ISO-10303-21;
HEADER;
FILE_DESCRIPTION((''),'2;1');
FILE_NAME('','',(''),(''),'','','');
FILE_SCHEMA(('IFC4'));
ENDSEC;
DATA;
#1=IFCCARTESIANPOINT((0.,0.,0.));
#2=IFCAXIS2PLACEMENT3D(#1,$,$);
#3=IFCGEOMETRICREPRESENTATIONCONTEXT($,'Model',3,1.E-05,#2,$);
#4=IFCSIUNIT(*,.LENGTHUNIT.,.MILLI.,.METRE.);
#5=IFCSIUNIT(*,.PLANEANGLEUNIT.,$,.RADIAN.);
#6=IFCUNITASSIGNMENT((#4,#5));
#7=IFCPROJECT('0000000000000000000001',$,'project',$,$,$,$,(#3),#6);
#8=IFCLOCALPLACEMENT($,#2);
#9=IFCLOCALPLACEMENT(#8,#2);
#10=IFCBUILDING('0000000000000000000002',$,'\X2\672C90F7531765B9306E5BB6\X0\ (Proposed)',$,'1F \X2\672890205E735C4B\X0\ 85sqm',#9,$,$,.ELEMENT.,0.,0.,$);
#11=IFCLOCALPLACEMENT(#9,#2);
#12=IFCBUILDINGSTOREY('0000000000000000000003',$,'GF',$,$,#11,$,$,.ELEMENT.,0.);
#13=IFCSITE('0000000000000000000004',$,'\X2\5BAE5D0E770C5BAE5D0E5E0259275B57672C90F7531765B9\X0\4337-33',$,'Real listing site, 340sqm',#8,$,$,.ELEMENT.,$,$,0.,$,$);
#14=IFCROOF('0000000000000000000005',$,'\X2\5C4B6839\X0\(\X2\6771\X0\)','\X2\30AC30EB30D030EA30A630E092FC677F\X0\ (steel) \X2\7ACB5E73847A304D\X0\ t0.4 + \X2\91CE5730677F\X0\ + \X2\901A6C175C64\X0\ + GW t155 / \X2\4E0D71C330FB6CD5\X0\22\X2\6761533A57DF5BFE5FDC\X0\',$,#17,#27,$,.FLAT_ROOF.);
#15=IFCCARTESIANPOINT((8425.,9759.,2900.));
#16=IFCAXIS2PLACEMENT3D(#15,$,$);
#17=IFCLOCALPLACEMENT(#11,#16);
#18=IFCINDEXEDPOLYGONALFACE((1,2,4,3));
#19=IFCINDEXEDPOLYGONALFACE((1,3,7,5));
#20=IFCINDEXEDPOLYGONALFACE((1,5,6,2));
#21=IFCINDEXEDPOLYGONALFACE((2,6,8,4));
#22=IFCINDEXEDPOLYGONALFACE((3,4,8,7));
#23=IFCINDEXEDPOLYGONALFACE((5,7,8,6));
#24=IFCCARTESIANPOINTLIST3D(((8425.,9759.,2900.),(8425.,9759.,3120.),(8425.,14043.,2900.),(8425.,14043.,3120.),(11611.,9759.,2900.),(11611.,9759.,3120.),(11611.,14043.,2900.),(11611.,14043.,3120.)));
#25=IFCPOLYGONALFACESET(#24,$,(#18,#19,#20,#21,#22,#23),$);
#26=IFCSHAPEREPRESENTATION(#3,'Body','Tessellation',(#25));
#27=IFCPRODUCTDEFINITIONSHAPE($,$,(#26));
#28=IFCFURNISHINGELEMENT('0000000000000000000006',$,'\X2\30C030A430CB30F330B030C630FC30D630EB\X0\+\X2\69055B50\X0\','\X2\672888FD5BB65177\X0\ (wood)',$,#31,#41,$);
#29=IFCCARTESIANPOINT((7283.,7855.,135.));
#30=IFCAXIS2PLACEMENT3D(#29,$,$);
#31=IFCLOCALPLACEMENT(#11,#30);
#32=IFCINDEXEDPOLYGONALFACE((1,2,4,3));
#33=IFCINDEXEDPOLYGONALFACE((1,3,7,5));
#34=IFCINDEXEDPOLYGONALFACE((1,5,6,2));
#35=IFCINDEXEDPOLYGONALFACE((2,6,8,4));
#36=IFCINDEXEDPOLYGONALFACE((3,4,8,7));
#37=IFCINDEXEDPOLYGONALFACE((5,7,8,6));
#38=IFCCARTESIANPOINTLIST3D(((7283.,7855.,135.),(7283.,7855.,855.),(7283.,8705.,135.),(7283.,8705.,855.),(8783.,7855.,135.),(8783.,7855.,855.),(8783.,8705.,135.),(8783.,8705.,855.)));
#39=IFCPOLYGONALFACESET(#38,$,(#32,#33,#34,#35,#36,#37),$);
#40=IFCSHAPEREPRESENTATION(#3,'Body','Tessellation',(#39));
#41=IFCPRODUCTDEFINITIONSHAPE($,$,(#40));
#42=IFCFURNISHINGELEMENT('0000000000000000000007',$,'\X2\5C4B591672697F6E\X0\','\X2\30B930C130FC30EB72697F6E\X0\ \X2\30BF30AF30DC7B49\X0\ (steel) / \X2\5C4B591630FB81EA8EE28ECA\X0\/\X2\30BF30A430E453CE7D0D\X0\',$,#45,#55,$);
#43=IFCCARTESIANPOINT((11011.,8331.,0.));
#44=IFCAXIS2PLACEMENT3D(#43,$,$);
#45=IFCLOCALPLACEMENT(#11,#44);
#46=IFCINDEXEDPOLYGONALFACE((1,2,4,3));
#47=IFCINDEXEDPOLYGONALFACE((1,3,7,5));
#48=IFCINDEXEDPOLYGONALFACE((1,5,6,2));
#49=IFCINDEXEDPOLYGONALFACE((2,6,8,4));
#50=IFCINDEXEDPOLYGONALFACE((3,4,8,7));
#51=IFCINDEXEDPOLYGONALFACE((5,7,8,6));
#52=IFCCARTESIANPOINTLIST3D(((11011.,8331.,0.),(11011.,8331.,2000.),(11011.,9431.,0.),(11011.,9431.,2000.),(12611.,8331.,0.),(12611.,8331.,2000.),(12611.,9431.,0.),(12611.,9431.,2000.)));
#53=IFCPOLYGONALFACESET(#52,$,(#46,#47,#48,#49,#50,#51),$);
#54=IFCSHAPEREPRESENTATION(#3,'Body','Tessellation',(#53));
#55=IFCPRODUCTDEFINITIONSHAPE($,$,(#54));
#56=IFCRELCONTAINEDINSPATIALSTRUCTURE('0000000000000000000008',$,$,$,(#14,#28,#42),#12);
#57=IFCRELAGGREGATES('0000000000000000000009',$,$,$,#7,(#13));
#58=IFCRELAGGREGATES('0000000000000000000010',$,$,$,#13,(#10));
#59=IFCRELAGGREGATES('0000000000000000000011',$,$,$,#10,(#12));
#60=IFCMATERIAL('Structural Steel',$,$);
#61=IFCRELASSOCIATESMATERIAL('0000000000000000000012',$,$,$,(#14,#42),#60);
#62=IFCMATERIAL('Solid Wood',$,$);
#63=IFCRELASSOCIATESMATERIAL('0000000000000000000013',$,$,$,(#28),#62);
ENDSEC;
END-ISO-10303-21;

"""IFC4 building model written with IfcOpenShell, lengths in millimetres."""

from ifc_helpers import new_model, si_unit, frame, frame_2d, origin, place, context, project, spatial, rectangle, extrude, material, element, save


model = new_model("IFC4")

# Units and contexts
model_context = context("Model", 3, precision=1e-05, world=origin())
ifc_project = project(units=[si_unit("LENGTHUNIT", "METRE", prefix="MILLI"), si_unit("PLANEANGLEUNIT", "RADIAN")], contexts=[model_context])

# Site, building, storey
site_placement = place(None, origin())
site = spatial("IfcSite", under=ifc_project, at=site_placement, Name="宮崎県宮崎市大字本郷北方4337-33", ObjectType="Real listing site, 340sqm", CompositionType="ELEMENT", RefElevation=0.0)
building_placement = place(site_placement, origin())
building = spatial("IfcBuilding", under=site, at=building_placement, Name="本郷北方の家 (Proposed)", ObjectType="1F 木造平屋 85sqm", CompositionType="ELEMENT", ElevationOfRefHeight=0.0, ElevationOfTerrain=0.0)
storey_placement = place(building_placement, origin())
storey = spatial("IfcBuildingStorey", under=building, at=storey_placement, Name="GF", CompositionType="ELEMENT", Elevation=0.0)

# Shared definitions
ifc_material_1 = material(Name="Solid Wood")

# Roof
ifc_material_2 = material(Name="Structural Steel")
roof_1_placement = place(storey_placement, frame((8425.0, 9759.0, 2900.0)))
element("IfcRoof", 1, at=roof_1_placement, inside=storey, material=ifc_material_2, Name="屋根(東)", Description="ガルバリウム鋼板 (steel) 立平葺き t0.4 + 野地板 + 通気層 + GW t155 / 不燃・法22条区域対応", PredefinedType="FLAT_ROOF", context=model_context, shape_type="SweptSolid", body=[
    extrude(rectangle(XDim=3186.0, YDim=4284.0, at=frame_2d((1593.0, 2142.0))), frame((8425.0, 9759.0, 2900.0)), (0.0, 0.0, 1.0), 220.0),
])

# Furnishing elements
furnishing_1_placement = place(storey_placement, frame((7283.0, 7855.0, 135.0)))
element("IfcFurnishingElement", 2, at=furnishing_1_placement, inside=storey, material=ifc_material_1, Name="ダイニングテーブル+椅子", Description="木製家具 (wood)", context=model_context, shape_type="SweptSolid", body=[
    extrude(rectangle(XDim=1500.0, YDim=850.0, at=frame_2d((750.0, 425.0))), frame((7283.0, 7855.0, 135.0)), (0.0, 0.0, 1.0), 720.0),
])
furnishing_2_placement = place(storey_placement, frame((11011.0, 8331.0, 0.0)))
element("IfcFurnishingElement", 3, at=furnishing_2_placement, inside=storey, material=ifc_material_2, Name="屋外物置", Description="スチール物置 タクボ等 (steel) / 屋外・自転車/タイヤ収納", context=model_context, shape_type="SweptSolid", body=[
    extrude(rectangle(XDim=1600.0, YDim=1100.0, at=frame_2d((800.0, 550.0))), frame((11011.0, 8331.0, 0.0)), (0.0, 0.0, 1.0), 2000.0),
])

save(model, "model.ifc")
